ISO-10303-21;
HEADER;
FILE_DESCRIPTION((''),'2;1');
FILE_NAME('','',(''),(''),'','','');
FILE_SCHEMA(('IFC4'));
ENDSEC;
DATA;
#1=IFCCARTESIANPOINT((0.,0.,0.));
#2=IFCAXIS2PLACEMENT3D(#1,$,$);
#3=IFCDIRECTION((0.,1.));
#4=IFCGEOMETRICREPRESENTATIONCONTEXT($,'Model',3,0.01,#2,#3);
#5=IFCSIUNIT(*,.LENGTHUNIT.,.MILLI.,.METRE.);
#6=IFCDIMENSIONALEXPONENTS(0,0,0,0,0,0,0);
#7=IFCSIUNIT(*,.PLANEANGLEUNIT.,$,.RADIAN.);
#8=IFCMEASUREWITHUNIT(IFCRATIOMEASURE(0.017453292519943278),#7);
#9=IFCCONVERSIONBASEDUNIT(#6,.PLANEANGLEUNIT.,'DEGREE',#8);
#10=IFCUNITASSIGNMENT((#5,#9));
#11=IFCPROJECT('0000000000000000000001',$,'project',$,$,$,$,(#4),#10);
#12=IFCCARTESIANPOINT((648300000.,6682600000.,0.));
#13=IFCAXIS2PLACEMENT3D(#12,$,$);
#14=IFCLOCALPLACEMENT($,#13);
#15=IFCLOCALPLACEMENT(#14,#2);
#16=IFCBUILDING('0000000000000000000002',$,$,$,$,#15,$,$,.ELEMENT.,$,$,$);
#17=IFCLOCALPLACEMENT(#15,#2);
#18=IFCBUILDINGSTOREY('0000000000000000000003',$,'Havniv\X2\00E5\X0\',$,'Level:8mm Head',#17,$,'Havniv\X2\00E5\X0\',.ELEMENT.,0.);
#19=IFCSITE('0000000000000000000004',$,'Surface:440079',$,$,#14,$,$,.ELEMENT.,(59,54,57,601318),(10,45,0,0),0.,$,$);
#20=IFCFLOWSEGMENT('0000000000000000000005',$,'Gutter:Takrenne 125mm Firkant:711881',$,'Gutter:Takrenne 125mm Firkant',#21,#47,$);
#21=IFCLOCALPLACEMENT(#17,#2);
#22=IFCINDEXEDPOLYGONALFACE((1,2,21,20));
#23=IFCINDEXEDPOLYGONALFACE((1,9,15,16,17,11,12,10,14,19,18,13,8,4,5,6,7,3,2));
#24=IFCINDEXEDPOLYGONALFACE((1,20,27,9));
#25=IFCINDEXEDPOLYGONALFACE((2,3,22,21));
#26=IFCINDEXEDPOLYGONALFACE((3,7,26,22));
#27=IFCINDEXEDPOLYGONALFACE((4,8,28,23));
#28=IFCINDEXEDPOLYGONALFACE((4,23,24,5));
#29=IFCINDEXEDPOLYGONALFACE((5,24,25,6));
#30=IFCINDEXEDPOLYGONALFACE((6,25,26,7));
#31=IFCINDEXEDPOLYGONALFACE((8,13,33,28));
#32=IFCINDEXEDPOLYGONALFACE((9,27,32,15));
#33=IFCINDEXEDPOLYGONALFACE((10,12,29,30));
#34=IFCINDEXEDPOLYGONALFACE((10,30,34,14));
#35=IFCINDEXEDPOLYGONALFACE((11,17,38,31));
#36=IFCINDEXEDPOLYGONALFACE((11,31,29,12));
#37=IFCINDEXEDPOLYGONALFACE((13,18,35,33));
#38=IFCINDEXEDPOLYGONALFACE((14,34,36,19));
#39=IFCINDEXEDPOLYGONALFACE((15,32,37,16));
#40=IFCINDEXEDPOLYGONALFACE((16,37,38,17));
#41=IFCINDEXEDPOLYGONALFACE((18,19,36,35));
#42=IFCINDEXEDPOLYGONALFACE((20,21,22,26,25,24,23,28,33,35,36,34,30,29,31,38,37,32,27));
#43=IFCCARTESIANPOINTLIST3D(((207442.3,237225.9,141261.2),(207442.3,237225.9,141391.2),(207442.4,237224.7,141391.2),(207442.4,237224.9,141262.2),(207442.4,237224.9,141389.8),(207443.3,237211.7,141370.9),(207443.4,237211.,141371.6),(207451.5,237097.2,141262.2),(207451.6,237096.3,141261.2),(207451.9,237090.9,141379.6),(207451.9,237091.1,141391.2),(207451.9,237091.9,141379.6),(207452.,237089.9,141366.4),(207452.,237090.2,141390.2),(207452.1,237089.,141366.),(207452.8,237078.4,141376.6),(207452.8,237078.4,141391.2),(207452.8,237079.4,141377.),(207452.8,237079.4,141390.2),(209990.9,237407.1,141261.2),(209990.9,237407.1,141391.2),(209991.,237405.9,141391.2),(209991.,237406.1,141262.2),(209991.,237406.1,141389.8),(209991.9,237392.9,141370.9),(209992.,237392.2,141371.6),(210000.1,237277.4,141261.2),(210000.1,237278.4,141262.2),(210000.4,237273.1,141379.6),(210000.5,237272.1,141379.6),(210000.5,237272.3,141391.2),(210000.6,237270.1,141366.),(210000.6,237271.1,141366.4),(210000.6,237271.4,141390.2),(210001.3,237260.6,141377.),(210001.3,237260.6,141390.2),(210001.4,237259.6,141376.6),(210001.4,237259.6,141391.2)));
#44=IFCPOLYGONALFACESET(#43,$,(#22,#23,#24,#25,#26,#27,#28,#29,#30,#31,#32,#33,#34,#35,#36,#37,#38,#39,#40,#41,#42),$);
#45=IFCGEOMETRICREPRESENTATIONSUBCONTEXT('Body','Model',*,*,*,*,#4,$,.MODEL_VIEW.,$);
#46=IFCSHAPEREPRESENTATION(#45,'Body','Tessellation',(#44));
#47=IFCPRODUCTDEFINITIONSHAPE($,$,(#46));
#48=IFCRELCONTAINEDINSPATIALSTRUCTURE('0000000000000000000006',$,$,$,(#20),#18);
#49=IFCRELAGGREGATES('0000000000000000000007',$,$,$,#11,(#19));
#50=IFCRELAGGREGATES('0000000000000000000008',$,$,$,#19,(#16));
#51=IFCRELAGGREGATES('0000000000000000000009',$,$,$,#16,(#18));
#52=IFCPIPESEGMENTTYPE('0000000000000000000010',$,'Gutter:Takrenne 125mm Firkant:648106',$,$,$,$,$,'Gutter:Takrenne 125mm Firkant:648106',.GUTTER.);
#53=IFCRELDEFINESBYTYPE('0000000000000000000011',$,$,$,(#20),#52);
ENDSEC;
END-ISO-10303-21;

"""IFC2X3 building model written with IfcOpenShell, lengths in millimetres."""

from ifc_helpers import new_model, entity, si_unit, converted_unit, direction, frame, origin, place, context, subcontext, project, spatial, polyline, outline, extrude, source, transform, mapped, type_object, type_shapes, element, save


model = new_model("IFC2X3")

# Units and contexts
model_context = context("Model", 3, precision=0.01, world=origin(), true_north=direction((0.0, 1.0)))
body_context = subcontext(model_context, "Body", "Model", "MODEL_VIEW")
ifc_project = project(units=[si_unit("LENGTHUNIT", "METRE", prefix="MILLI"), converted_unit("PLANEANGLEUNIT", "DEGREE", entity("IfcRatioMeasure", 0.017453292519943278), si_unit("PLANEANGLEUNIT", "RADIAN"), dimensions=[0, 0, 0, 0, 0, 0, 0])], contexts=[model_context])

# Site, building, storey
site_placement = place(None, frame((648300000.0, 6682600000.0, 0.0)))
site = spatial("IfcSite", under=ifc_project, at=site_placement, Name="Surface:440079", CompositionType="ELEMENT", RefLatitude=(59, 54, 57, 601318), RefLongitude=(10, 45, 0, 0), RefElevation=0.0)
building_placement = place(site_placement, origin())
building = spatial("IfcBuilding", under=site, at=building_placement, CompositionType="ELEMENT")
storey_placement = place(building_placement, origin())
storey = spatial("IfcBuildingStorey", under=building, at=storey_placement, Name="Havnivå", ObjectType="Level:8mm Head", LongName="Havnivå", CompositionType="ELEMENT", Elevation=0.0)

# Flow segment
pipe_segment_type_1 = type_object("IfcPipeSegmentType", Name="Gutter:Takrenne 125mm Firkant:648106", ElementType="Gutter:Takrenne 125mm Firkant:648106", PredefinedType="GUTTER")
shared_shape_1 = source(origin(), body_context, "Body", "SweptSolid", [
    extrude(outline(polyline([(-95.1, -89.3), (34.9, -89.3), (34.9, -88.0), (15.3, -74.3), (14.6, -75.0), (33.5, -88.3), (-94.1, -88.3), (-94.1, 39.8), (10.1, 47.1), (20.7, 57.7), (33.9, 57.7), (33.9, 46.8), (23.3, 46.1), (23.3, 45.1), (34.9, 45.9), (34.9, 58.7), (20.3, 58.7), (9.7, 48.1), (-95.1, 40.7), (-95.1, -89.3)])), frame((207448.7, 237136.9, 141356.3), z_axis=(0.997483, 0.070908, 0.0), x_axis=(0.0, 0.0, 1.0)), (0.0, 0.0, 1.0), 2555.0),
])
type_shapes(pipe_segment_type_1, [shared_shape_1])
flow_segment_1_placement = place(storey_placement, origin())
element("IfcFlowSegment", 1, at=flow_segment_1_placement, inside=storey, type_object=pipe_segment_type_1, Name="Gutter:Takrenne 125mm Firkant:711881", ObjectType="Gutter:Takrenne 125mm Firkant", context=body_context, shape_type="MappedRepresentation", body=[
    mapped(shared_shape_1, transform((0.0, 0.0, 0.0), scale=1.0)),
])

save(model, "model.ifc")
